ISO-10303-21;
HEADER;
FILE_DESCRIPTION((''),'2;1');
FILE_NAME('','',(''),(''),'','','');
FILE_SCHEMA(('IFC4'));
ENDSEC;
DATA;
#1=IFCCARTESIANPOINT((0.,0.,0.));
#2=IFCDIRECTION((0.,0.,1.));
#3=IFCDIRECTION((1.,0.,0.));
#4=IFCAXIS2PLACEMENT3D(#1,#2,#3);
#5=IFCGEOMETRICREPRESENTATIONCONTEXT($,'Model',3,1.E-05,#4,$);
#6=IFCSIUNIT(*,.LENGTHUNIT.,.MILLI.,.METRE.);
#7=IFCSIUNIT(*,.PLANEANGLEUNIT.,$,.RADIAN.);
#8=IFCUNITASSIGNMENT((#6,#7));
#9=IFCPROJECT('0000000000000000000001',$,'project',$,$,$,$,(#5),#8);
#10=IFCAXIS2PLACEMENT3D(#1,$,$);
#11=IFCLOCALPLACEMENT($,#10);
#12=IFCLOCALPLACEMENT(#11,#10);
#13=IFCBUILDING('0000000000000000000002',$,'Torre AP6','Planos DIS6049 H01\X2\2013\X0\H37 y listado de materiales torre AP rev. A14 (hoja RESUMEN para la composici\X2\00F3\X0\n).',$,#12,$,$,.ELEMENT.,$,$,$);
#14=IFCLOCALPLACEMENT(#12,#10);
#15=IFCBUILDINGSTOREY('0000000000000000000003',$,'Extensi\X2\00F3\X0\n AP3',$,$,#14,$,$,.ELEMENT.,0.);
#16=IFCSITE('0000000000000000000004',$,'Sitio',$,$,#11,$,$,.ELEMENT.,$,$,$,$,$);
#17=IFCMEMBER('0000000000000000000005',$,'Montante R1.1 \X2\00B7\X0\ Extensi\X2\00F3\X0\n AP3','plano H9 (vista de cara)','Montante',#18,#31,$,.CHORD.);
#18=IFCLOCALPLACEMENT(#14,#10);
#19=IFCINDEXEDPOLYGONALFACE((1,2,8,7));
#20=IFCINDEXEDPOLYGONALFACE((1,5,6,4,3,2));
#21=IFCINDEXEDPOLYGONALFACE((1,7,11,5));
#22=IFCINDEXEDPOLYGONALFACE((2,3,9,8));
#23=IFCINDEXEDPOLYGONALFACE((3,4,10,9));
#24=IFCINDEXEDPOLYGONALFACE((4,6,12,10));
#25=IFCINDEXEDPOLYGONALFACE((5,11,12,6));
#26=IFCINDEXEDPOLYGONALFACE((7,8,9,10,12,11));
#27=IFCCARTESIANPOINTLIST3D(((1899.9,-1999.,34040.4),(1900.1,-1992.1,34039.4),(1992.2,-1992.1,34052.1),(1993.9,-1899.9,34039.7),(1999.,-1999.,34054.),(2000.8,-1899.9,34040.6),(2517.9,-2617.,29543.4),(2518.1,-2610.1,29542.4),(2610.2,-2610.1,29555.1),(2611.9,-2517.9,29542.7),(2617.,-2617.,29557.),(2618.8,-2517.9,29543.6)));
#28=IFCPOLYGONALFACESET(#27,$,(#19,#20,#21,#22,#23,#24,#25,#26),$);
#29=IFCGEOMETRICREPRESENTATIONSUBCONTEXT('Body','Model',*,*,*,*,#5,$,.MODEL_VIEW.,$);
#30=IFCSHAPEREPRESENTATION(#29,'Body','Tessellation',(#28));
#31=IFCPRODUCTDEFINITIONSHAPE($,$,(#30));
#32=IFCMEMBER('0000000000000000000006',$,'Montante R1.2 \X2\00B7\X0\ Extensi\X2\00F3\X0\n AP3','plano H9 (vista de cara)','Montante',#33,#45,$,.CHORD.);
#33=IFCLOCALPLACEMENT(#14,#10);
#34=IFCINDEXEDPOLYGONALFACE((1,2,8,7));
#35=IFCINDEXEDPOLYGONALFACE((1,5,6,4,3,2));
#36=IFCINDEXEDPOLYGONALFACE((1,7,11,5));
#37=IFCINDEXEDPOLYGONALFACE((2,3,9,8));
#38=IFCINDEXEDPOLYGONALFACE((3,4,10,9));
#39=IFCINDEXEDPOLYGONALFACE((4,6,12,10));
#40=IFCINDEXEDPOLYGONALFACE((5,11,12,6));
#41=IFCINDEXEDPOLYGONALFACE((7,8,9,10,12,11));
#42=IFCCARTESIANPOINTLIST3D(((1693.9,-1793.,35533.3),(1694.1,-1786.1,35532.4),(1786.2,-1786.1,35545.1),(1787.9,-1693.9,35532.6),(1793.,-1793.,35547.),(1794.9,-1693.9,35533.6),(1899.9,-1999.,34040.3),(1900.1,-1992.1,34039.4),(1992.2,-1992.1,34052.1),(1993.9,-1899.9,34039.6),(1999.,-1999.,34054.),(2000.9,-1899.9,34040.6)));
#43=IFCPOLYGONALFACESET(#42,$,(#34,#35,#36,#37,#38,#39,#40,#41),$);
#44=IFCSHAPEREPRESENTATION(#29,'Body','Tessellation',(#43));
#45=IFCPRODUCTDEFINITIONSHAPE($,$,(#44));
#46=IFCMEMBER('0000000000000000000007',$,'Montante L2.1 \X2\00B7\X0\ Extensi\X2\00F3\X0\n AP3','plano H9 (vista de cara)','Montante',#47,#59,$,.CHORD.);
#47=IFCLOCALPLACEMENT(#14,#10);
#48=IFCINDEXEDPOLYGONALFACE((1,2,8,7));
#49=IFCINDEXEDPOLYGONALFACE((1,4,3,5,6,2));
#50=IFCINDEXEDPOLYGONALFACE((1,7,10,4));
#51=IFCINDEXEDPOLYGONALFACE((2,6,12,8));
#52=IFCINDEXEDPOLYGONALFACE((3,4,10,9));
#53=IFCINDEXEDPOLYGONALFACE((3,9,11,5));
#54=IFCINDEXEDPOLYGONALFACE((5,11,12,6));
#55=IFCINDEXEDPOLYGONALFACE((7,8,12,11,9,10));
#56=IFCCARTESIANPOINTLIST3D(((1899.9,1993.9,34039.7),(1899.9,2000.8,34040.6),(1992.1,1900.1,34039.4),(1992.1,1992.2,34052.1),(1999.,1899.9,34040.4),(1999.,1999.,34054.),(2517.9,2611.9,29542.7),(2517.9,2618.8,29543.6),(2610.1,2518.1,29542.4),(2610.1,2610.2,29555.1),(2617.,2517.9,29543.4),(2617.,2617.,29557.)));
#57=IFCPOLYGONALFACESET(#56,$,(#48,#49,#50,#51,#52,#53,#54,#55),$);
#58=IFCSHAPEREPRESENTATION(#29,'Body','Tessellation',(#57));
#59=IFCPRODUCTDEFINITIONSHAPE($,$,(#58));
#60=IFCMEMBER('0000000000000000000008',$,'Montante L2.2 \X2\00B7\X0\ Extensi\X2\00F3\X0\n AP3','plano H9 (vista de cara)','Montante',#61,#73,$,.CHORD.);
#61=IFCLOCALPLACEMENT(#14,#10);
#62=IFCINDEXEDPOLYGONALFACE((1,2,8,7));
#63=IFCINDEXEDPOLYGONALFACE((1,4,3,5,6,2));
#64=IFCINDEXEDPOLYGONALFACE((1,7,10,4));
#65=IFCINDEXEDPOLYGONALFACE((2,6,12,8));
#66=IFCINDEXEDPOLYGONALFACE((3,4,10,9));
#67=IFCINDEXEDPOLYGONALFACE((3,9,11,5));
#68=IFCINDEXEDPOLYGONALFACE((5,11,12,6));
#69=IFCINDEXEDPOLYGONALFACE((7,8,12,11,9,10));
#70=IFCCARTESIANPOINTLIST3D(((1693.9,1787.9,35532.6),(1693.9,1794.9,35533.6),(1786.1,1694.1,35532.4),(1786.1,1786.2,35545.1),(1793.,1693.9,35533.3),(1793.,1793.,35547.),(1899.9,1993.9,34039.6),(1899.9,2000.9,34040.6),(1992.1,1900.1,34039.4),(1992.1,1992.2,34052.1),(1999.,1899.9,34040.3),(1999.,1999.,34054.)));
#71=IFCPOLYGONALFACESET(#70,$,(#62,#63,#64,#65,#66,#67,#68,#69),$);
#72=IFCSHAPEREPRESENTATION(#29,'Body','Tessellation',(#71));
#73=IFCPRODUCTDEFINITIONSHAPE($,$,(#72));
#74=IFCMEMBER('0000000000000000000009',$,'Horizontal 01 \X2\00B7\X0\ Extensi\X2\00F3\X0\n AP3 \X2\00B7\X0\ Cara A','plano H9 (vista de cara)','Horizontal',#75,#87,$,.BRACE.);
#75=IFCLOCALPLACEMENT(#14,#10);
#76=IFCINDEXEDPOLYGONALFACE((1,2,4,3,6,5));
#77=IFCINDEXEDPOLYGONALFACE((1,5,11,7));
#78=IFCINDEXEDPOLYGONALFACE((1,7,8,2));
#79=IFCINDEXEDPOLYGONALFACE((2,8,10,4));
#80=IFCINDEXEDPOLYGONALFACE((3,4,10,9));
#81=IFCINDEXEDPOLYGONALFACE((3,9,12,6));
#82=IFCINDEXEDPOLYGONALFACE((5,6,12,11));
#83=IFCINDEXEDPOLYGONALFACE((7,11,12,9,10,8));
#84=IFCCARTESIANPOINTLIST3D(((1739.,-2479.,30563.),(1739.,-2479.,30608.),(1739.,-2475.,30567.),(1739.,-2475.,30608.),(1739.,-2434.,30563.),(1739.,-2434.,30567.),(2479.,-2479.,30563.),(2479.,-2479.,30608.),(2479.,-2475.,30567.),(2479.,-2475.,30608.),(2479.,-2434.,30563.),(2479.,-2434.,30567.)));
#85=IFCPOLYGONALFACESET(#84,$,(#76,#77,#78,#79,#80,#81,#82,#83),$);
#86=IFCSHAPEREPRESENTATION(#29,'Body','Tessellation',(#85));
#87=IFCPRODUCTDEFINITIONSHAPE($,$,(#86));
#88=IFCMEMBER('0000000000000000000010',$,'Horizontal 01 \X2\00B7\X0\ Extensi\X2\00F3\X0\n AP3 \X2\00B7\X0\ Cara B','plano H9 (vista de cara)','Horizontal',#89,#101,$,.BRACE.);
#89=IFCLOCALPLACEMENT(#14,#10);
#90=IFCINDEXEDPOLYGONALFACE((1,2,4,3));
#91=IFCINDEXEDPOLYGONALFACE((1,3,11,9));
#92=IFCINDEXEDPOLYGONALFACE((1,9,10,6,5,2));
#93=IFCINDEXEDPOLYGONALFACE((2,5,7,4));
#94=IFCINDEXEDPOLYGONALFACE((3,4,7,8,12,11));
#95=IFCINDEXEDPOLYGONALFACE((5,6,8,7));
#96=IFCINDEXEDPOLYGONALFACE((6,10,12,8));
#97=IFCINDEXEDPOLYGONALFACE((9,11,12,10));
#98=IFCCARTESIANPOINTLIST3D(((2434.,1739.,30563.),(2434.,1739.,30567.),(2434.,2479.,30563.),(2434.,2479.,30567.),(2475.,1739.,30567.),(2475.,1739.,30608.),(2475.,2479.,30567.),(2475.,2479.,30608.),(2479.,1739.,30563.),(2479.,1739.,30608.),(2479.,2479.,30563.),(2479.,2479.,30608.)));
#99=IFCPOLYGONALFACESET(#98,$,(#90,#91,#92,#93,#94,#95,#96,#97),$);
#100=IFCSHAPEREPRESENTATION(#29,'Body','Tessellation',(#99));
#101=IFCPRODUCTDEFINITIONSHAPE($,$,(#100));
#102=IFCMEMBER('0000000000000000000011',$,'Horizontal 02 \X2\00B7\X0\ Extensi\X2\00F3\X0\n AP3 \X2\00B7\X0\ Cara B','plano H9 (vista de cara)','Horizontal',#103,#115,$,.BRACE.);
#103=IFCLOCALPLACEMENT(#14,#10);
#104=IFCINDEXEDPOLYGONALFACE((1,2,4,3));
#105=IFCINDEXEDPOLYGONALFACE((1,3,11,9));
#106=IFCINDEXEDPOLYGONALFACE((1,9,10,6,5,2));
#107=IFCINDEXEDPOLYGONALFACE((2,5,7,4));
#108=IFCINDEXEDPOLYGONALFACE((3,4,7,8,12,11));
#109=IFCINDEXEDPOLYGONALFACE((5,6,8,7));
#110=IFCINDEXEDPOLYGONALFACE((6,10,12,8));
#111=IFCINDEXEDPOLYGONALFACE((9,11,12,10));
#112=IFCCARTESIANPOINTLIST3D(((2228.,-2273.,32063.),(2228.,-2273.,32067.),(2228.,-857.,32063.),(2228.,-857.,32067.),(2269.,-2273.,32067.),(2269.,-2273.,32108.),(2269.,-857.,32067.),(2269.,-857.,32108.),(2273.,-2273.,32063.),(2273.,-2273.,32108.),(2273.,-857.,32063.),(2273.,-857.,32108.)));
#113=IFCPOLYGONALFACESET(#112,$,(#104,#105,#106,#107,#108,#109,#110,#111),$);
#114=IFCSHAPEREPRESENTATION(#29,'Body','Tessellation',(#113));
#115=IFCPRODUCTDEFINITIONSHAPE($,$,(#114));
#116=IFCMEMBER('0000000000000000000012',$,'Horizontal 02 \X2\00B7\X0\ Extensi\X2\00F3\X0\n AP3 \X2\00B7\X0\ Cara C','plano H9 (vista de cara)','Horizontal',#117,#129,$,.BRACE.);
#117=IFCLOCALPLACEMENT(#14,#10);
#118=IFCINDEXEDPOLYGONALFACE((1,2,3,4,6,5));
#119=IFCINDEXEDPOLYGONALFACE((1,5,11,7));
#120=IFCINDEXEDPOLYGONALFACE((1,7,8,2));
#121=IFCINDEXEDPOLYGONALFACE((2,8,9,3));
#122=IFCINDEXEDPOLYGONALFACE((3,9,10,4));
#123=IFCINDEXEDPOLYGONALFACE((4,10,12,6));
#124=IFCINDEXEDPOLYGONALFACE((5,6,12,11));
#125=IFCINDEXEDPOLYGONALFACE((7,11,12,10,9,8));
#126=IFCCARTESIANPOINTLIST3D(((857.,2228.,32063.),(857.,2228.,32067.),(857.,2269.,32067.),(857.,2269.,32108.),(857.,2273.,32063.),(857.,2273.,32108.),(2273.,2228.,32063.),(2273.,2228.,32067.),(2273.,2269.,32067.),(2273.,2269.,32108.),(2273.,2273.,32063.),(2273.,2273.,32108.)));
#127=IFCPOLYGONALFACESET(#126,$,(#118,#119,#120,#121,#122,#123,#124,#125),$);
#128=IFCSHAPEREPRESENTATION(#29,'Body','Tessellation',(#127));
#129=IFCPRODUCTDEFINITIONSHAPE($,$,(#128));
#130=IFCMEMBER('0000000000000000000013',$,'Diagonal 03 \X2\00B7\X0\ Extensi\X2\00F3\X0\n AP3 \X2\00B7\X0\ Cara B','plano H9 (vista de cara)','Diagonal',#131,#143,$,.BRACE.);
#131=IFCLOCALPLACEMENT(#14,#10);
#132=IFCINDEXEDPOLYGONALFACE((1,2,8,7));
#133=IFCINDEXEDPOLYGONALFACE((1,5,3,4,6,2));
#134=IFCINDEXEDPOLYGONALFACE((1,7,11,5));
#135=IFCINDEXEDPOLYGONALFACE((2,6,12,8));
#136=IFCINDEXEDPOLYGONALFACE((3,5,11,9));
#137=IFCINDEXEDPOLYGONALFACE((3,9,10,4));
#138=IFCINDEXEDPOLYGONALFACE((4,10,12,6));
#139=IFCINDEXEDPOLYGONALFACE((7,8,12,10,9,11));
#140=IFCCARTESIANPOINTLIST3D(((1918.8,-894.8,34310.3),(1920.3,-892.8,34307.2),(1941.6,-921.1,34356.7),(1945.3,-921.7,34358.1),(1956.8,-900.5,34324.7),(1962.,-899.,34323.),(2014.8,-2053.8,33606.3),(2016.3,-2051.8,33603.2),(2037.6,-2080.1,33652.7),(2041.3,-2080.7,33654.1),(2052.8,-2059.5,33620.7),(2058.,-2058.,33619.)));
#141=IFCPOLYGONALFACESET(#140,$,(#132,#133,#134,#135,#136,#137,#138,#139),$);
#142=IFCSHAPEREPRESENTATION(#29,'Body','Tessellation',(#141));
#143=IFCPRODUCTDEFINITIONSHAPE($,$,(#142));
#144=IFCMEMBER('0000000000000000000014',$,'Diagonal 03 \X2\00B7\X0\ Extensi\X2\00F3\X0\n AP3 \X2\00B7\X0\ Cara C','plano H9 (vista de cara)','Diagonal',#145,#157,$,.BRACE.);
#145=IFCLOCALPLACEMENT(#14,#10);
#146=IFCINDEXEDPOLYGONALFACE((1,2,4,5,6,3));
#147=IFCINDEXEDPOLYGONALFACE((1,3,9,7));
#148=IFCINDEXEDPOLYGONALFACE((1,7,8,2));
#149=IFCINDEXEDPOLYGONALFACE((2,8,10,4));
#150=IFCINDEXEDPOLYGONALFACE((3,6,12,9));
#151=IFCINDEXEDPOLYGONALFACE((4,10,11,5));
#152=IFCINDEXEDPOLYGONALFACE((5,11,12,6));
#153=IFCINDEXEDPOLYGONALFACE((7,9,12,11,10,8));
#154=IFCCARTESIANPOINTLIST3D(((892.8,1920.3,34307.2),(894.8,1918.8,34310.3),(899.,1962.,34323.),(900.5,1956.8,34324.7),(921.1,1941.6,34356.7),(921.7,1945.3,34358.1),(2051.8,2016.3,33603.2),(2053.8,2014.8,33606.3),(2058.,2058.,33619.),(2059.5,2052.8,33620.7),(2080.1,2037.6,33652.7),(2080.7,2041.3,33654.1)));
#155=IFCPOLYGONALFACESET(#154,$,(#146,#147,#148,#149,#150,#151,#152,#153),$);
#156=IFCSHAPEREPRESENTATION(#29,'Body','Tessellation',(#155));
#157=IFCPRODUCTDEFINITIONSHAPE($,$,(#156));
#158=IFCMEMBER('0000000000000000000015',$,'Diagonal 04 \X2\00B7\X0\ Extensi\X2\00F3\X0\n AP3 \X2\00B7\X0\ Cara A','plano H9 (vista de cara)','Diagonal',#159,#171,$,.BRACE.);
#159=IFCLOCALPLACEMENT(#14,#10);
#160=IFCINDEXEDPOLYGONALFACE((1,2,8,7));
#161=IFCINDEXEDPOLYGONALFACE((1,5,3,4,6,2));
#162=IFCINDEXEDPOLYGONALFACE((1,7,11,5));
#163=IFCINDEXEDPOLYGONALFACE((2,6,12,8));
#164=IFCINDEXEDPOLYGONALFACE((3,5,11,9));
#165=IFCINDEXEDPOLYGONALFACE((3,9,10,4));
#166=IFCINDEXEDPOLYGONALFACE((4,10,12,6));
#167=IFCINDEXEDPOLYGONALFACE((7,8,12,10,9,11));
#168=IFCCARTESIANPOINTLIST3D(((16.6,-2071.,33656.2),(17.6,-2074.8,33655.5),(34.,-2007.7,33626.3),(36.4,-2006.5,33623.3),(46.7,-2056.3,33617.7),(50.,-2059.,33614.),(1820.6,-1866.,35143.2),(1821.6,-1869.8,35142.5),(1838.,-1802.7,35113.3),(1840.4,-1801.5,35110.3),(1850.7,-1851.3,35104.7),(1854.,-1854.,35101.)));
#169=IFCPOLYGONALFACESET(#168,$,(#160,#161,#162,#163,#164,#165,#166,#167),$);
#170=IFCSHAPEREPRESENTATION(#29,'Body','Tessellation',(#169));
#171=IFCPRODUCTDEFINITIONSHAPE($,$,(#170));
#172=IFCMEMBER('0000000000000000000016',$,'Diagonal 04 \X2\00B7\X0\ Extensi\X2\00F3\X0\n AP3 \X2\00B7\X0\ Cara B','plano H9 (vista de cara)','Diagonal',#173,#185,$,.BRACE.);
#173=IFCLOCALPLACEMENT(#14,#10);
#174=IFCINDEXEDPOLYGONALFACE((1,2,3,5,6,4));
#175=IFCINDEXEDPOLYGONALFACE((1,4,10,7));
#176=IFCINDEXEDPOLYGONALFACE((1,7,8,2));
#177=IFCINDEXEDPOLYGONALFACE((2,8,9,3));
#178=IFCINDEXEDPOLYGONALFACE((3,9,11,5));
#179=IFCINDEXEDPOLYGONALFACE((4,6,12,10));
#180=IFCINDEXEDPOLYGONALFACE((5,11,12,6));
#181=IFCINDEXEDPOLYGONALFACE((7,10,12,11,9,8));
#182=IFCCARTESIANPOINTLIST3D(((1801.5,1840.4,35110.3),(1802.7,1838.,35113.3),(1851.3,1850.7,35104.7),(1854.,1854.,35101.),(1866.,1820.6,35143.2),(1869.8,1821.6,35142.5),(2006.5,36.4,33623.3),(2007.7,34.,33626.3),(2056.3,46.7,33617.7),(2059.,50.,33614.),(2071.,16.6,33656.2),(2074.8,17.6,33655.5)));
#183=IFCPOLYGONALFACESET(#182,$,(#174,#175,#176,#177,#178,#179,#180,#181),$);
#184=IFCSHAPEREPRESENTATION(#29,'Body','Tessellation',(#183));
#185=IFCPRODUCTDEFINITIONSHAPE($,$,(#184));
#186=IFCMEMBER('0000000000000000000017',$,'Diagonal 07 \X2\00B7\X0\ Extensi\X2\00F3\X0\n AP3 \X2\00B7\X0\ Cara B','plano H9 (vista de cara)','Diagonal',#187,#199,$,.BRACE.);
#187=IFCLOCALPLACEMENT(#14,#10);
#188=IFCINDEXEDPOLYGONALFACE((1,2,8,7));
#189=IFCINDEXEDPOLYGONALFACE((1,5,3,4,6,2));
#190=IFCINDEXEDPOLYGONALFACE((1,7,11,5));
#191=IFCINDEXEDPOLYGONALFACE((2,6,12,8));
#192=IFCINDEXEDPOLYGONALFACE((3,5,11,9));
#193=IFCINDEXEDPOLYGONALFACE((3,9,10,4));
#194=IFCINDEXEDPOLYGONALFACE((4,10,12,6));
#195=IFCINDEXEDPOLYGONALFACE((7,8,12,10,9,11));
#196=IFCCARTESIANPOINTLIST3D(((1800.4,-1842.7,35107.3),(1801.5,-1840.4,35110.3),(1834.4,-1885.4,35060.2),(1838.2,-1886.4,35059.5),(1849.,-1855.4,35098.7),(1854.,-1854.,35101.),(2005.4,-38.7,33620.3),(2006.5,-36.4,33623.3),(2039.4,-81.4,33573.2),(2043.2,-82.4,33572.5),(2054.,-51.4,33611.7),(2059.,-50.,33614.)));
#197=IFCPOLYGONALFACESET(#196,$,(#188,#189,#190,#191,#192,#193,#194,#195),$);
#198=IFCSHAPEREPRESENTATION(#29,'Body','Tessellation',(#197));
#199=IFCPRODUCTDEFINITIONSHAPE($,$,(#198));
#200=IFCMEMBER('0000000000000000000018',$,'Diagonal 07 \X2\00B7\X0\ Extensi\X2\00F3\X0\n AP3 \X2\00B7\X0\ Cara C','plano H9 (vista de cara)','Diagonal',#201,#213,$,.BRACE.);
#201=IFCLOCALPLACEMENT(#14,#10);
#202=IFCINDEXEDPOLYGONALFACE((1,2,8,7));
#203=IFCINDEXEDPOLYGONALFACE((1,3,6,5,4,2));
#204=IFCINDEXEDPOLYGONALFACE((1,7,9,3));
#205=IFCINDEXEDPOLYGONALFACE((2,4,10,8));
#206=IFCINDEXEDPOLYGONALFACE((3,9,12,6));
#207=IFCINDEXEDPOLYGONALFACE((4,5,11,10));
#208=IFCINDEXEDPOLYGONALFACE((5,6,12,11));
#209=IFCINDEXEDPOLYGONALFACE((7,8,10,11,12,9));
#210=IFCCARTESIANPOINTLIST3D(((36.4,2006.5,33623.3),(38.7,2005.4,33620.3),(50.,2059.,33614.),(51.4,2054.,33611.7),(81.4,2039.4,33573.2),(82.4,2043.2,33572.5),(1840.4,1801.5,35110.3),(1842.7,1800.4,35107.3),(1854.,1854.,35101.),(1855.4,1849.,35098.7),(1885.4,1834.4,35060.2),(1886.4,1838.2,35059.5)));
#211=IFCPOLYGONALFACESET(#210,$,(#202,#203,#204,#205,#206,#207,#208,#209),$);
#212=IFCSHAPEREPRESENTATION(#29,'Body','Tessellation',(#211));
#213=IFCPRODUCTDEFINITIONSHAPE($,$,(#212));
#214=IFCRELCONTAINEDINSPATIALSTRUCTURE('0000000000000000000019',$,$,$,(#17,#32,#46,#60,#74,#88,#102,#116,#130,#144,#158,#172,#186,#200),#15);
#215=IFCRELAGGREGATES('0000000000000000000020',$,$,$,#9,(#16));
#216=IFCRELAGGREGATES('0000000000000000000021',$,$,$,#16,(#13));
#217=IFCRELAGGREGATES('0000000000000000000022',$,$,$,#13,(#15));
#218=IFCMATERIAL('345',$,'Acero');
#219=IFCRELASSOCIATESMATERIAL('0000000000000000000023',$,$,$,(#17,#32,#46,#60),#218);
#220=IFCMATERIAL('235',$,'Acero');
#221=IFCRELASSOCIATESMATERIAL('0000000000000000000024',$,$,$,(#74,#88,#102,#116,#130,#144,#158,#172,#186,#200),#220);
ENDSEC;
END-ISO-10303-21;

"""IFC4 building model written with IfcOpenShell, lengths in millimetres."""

from ifc_helpers import new_model, si_unit, frame, frame_2d, origin, origin_with_axes, place, context, subcontext, project, spatial, l_section, extrude, material, element, save


model = new_model("IFC4")

# Units and contexts
model_context = context("Model", 3, precision=1e-05, world=origin_with_axes())
body_context = subcontext(model_context, "Body", "Model", "MODEL_VIEW")
ifc_project = project(units=[si_unit("LENGTHUNIT", "METRE", prefix="MILLI"), si_unit("PLANEANGLEUNIT", "RADIAN")], contexts=[model_context])

# Site, building, storey
site_placement = place(None, origin())
site = spatial("IfcSite", under=ifc_project, at=site_placement, Name="Sitio", CompositionType="ELEMENT")
building_placement = place(site_placement, origin())
building = spatial("IfcBuilding", under=site, at=building_placement, Name="Torre AP6", Description="Planos DIS6049 H01–H37 y listado de materiales torre AP rev. A14 (hoja RESUMEN para la composición).", CompositionType="ELEMENT")
storey_placement = place(building_placement, origin())
storey = spatial("IfcBuildingStorey", under=building, at=storey_placement, Name="Extensión AP3", CompositionType="ELEMENT", Elevation=0.0)

# Members
ifc_material_1 = material(Name="345", Category="Acero")
member_1_placement = place(storey_placement, frame((2617.0, -2617.0, 29557.0), z_axis=(-0.134901, 0.134901, 0.981633), x_axis=(0.018366, 0.990859, -0.133645)))
element("IfcMember", 1, at=member_1_placement, inside=storey, material=ifc_material_1, Name="Montante R1.1 · Extensión AP3", Description="plano H9 (vista de cara)", ObjectType="Montante", PredefinedType="CHORD", context=body_context, shape_type="SweptSolid", body=[
    extrude(l_section(Depth=100.0, Width=100.0, Thickness=7.0, at=frame_2d((50.0, 50.0))), None, (0.0, 0.0, 1.0), 4581.1),
])
member_2_placement = place(storey_placement, frame((1999.0, -1999.0, 34054.0), z_axis=(-0.135423, 0.135423, 0.981489), x_axis=(0.01851, 0.990788, -0.134152)))
element("IfcMember", 2, at=member_2_placement, inside=storey, material=ifc_material_1, Name="Montante R1.2 · Extensión AP3", Description="plano H9 (vista de cara)", ObjectType="Montante", PredefinedType="CHORD", context=body_context, shape_type="SweptSolid", body=[
    extrude(l_section(Depth=100.0, Width=100.0, Thickness=7.0, at=frame_2d((50.0, 50.0))), None, (0.0, 0.0, 1.0), 1521.2),
])
member_3_placement = place(storey_placement, frame((2617.0, 2617.0, 29557.0), z_axis=(-0.134901, -0.134901, 0.981633), x_axis=(-0.990859, 0.018366, -0.133645)))
element("IfcMember", 3, at=member_3_placement, inside=storey, material=ifc_material_1, Name="Montante L2.1 · Extensión AP3", Description="plano H9 (vista de cara)", ObjectType="Montante", PredefinedType="CHORD", context=body_context, shape_type="SweptSolid", body=[
    extrude(l_section(Depth=100.0, Width=100.0, Thickness=7.0, at=frame_2d((50.0, 50.0))), None, (0.0, 0.0, 1.0), 4581.1),
])
member_4_placement = place(storey_placement, frame((1999.0, 1999.0, 34054.0), z_axis=(-0.135423, -0.135423, 0.981489), x_axis=(-0.990788, 0.01851, -0.134152)))
element("IfcMember", 4, at=member_4_placement, inside=storey, material=ifc_material_1, Name="Montante L2.2 · Extensión AP3", Description="plano H9 (vista de cara)", ObjectType="Montante", PredefinedType="CHORD", context=body_context, shape_type="SweptSolid", body=[
    extrude(l_section(Depth=100.0, Width=100.0, Thickness=7.0, at=frame_2d((50.0, 50.0))), None, (0.0, 0.0, 1.0), 1521.2),
])
ifc_material_2 = material(Name="235", Category="Acero")
for number, where, z_axis, x_axis, name in (
    (5, (1739.0, -2479.0, 30563.0), (1.0, 0.0, 0.0), (0.0, 1.0, 0.0), "Horizontal 01 · Extensión AP3 · Cara A"),
    (6, (2479.0, 1739.0, 30563.0), (0.0, 1.0, 0.0), (-1.0, 0.0, 0.0), "Horizontal 01 · Extensión AP3 · Cara B"),
):
    element("IfcMember", number, at=place(storey_placement, frame(where, z_axis=z_axis, x_axis=x_axis)), inside=storey, material=ifc_material_2, Name=name, Description="plano H9 (vista de cara)", ObjectType="Horizontal", PredefinedType="BRACE", context=body_context, shape_type="SweptSolid", body=[
        extrude(l_section(Depth=45.0, Width=45.0, Thickness=4.0, at=frame_2d((22.5, 22.5))), None, (0.0, 0.0, 1.0), 740.0),
    ])
for number, where, z_axis, x_axis, name in (
    (7, (2273.0, -2273.0, 32063.0), (0.0, 1.0, 0.0), (-1.0, 0.0, 0.0), "Horizontal 02 · Extensión AP3 · Cara B"),
    (8, (2273.0, 2273.0, 32063.0), (-1.0, 0.0, 0.0), (0.0, -1.0, 0.0), "Horizontal 02 · Extensión AP3 · Cara C"),
):
    element("IfcMember", number, at=place(storey_placement, frame(where, z_axis=z_axis, x_axis=x_axis)), inside=storey, material=ifc_material_2, Name=name, Description="plano H9 (vista de cara)", ObjectType="Horizontal", PredefinedType="BRACE", context=body_context, shape_type="SweptSolid", body=[
        extrude(l_section(Depth=45.0, Width=45.0, Thickness=4.0, at=frame_2d((22.5, 22.5))), None, (0.0, 0.0, 1.0), 1416.0),
    ])
for number, where, z_axis, x_axis, name in (
    (9, (2058.0, -2058.0, 33619.0), (-0.070617, 0.852549, 0.517855), (-0.925948, 0.137057, -0.351904), "Diagonal 03 · Extensión AP3 · Cara B"),
    (10, (2058.0, 2058.0, 33619.0), (-0.852549, -0.070617, 0.517855), (-0.137057, -0.925948, -0.351904), "Diagonal 03 · Extensión AP3 · Cara C"),
):
    element("IfcMember", number, at=place(storey_placement, frame(where, z_axis=z_axis, x_axis=x_axis)), inside=storey, material=ifc_material_2, Name=name, Description="plano H9 (vista de cara)", ObjectType="Diagonal", PredefinedType="BRACE", context=body_context, shape_type="SweptSolid", body=[
        extrude(l_section(Depth=45.0, Width=45.0, Thickness=4.0, at=frame_2d((22.5, 22.5))), None, (0.0, 0.0, 1.0), 1359.5),
    ])
for number, where, z_axis, x_axis, name in (
    (11, (50.0, -2059.0, 33614.0), (0.768697, 0.087352, 0.633621), (-0.247751, 0.953961, 0.169052), "Diagonal 04 · Extensión AP3 · Cara A"),
    (12, (2059.0, 50.0, 33614.0), (-0.087352, 0.768697, 0.633621), (-0.953961, -0.247751, 0.169052), "Diagonal 04 · Extensión AP3 · Cara B"),
):
    element("IfcMember", number, at=place(storey_placement, frame(where, z_axis=z_axis, x_axis=x_axis)), inside=storey, material=ifc_material_2, Name=name, Description="plano H9 (vista de cara)", ObjectType="Diagonal", PredefinedType="BRACE", context=body_context, shape_type="SweptSolid", body=[
        extrude(l_section(Depth=55.0, Width=55.0, Thickness=4.0, at=frame_2d((27.5, 27.5))), None, (0.0, 0.0, 1.0), 2346.8),
    ])
for number, where, z_axis, x_axis, name in (
    (13, (2059.0, -50.0, 33614.0), (-0.087352, -0.768697, 0.633621), (-0.953961, 0.247751, 0.169052), "Diagonal 07 · Extensión AP3 · Cara B"),
    (14, (50.0, 2059.0, 33614.0), (0.768697, -0.087352, 0.633621), (-0.247751, -0.953961, 0.169052), "Diagonal 07 · Extensión AP3 · Cara C"),
):
    element("IfcMember", number, at=place(storey_placement, frame(where, z_axis=z_axis, x_axis=x_axis)), inside=storey, material=ifc_material_2, Name=name, Description="plano H9 (vista de cara)", ObjectType="Diagonal", PredefinedType="BRACE", context=body_context, shape_type="SweptSolid", body=[
        extrude(l_section(Depth=55.0, Width=55.0, Thickness=4.0, at=frame_2d((27.5, 27.5))), None, (0.0, 0.0, 1.0), 2346.8),
    ])

save(model, "model.ifc")
